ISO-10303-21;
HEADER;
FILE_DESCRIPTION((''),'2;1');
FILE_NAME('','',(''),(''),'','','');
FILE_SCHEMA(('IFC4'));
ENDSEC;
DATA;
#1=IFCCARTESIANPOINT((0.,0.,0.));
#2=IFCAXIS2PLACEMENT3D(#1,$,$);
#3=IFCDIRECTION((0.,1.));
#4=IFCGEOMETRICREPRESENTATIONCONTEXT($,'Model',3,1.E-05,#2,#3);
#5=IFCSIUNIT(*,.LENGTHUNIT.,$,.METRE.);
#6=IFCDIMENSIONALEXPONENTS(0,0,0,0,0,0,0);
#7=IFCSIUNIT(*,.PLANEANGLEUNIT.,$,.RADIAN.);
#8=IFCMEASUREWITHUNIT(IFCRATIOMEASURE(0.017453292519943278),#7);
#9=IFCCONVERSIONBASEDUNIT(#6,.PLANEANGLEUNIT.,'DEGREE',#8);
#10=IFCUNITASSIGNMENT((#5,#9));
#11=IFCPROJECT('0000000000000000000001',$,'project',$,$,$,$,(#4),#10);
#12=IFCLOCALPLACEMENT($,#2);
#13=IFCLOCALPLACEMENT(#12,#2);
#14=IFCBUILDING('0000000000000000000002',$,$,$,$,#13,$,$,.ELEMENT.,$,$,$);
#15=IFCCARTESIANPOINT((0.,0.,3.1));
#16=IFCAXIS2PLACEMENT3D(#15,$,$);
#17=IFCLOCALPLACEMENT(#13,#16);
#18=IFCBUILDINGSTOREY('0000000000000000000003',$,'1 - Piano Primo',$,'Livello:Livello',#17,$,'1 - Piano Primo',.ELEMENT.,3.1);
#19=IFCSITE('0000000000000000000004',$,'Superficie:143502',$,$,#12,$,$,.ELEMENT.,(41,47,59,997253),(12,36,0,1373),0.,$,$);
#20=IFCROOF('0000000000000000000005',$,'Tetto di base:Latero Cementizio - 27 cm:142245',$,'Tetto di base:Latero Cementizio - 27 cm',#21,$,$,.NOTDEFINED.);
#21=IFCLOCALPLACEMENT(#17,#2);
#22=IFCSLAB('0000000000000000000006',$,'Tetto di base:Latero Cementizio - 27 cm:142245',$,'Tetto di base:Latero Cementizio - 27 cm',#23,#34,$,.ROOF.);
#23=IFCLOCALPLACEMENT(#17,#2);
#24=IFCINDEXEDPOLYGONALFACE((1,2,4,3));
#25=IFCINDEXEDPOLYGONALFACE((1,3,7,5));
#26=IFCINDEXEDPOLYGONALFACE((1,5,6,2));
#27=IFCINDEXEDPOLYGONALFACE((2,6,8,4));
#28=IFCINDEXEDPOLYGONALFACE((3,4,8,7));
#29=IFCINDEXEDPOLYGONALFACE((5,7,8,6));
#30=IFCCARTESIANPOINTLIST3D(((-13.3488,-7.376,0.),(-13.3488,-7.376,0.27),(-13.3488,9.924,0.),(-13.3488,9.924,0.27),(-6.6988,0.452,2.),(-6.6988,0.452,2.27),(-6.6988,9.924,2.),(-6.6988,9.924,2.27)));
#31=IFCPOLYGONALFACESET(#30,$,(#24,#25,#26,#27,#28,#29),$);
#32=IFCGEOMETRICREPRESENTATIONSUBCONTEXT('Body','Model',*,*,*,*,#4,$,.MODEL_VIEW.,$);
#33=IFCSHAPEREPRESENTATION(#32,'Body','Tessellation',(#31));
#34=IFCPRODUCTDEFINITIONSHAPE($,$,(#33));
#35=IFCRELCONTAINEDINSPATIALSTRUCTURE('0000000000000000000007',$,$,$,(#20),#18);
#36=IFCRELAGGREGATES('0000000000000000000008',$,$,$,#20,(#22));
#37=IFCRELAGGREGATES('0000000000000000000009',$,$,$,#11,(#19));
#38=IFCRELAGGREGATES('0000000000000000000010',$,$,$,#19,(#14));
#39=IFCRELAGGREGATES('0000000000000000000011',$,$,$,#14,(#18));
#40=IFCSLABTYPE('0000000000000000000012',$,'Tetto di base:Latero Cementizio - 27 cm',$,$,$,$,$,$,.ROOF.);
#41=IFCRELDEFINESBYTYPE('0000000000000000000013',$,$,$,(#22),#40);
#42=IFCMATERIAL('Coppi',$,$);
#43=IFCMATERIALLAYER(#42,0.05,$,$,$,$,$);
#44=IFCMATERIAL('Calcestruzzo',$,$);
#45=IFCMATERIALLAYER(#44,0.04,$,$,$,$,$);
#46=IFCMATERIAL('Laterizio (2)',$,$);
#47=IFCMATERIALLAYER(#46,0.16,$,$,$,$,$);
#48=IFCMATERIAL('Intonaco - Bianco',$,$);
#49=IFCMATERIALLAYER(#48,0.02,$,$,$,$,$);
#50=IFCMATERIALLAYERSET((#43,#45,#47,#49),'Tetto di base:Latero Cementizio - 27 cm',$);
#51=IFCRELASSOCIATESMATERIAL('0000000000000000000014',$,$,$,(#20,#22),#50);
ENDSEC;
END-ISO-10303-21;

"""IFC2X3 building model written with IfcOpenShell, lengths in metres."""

from ifc_helpers import new_model, entity, si_unit, converted_unit, direction, frame, origin, place, context, subcontext, project, spatial, polyline, outline, extrude, material, layer, layer_set, type_object, element, aggregate, save


model = new_model("IFC2X3")

# Units and contexts
model_context = context("Model", 3, precision=1e-05, world=origin(), true_north=direction((0.0, 1.0)))
body_context = subcontext(model_context, "Body", "Model", "MODEL_VIEW")
ifc_project = project(units=[si_unit("LENGTHUNIT", "METRE"), converted_unit("PLANEANGLEUNIT", "DEGREE", entity("IfcRatioMeasure", 0.017453292519943278), si_unit("PLANEANGLEUNIT", "RADIAN"), dimensions=[0, 0, 0, 0, 0, 0, 0])], contexts=[model_context])

# Site, building, storey
site_placement = place(None, origin())
site = spatial("IfcSite", under=ifc_project, at=site_placement, Name="Superficie:143502", CompositionType="ELEMENT", RefLatitude=(41, 47, 59, 997253), RefLongitude=(12, 36, 0, 1373), RefElevation=0.0)
building_placement = place(site_placement, origin())
building = spatial("IfcBuilding", under=site, at=building_placement, CompositionType="ELEMENT")
storey_placement = place(building_placement, frame((0.0, 0.0, 3.1)))
storey = spatial("IfcBuildingStorey", under=building, at=storey_placement, Name="1 - Piano Primo", ObjectType="Livello:Livello", LongName="1 - Piano Primo", CompositionType="ELEMENT", Elevation=3.1)

# Roof, slab
ifc_material_1 = material(Name="Coppi")
ifc_layer_1 = layer(ifc_material_1, 0.05)
ifc_material_2 = material(Name="Calcestruzzo")
ifc_layer_2 = layer(ifc_material_2, 0.04)
ifc_material_3 = material(Name="Laterizio (2)")
ifc_layer_3 = layer(ifc_material_3, 0.16)
ifc_material_4 = material(Name="Intonaco - Bianco")
ifc_layer_4 = layer(ifc_material_4, 0.02)
ifc_layer_set = layer_set([ifc_layer_1, ifc_layer_2, ifc_layer_3, ifc_layer_4], Name="Tetto di base:Latero Cementizio - 27 cm")
roof_placement = place(storey_placement, frame((-13.3488, -11.776, 0.0)))
roof = element("IfcRoof", 1, at=roof_placement, inside=storey, material=ifc_layer_set, Name="Tetto di base:Latero Cementizio - 27 cm:142245", ObjectType="Tetto di base:Latero Cementizio - 27 cm", ShapeType="NOTDEFINED")
slab_type_1 = type_object("IfcSlabType", Name="Tetto di base:Latero Cementizio - 27 cm", PredefinedType="ROOF")
slab_1_placement = place(roof_placement, origin())
slab_1 = element("IfcSlab", 2, at=slab_1_placement, type_object=slab_type_1, material=ifc_layer_set, Name="Tetto di base:Latero Cementizio - 27 cm:142245", ObjectType="Tetto di base:Latero Cementizio - 27 cm", PredefinedType="ROOF", context=body_context, shape_type="SweptSolid", body=[
    extrude(outline(polyline([(-3.4721, 8.65), (-3.4721, -8.65), (3.4721, -0.822), (3.4721, 8.65), (-3.4721, 8.65)])), frame((3.325, 13.05, 1.0), z_axis=(-0.288008, 0.0, 0.957628), x_axis=(0.957628, 0.0, 0.288008)), (0.288008, 0.0, 0.957628), 0.27),
])
aggregate(roof, [slab_1])

save(model, "model.ifc")
